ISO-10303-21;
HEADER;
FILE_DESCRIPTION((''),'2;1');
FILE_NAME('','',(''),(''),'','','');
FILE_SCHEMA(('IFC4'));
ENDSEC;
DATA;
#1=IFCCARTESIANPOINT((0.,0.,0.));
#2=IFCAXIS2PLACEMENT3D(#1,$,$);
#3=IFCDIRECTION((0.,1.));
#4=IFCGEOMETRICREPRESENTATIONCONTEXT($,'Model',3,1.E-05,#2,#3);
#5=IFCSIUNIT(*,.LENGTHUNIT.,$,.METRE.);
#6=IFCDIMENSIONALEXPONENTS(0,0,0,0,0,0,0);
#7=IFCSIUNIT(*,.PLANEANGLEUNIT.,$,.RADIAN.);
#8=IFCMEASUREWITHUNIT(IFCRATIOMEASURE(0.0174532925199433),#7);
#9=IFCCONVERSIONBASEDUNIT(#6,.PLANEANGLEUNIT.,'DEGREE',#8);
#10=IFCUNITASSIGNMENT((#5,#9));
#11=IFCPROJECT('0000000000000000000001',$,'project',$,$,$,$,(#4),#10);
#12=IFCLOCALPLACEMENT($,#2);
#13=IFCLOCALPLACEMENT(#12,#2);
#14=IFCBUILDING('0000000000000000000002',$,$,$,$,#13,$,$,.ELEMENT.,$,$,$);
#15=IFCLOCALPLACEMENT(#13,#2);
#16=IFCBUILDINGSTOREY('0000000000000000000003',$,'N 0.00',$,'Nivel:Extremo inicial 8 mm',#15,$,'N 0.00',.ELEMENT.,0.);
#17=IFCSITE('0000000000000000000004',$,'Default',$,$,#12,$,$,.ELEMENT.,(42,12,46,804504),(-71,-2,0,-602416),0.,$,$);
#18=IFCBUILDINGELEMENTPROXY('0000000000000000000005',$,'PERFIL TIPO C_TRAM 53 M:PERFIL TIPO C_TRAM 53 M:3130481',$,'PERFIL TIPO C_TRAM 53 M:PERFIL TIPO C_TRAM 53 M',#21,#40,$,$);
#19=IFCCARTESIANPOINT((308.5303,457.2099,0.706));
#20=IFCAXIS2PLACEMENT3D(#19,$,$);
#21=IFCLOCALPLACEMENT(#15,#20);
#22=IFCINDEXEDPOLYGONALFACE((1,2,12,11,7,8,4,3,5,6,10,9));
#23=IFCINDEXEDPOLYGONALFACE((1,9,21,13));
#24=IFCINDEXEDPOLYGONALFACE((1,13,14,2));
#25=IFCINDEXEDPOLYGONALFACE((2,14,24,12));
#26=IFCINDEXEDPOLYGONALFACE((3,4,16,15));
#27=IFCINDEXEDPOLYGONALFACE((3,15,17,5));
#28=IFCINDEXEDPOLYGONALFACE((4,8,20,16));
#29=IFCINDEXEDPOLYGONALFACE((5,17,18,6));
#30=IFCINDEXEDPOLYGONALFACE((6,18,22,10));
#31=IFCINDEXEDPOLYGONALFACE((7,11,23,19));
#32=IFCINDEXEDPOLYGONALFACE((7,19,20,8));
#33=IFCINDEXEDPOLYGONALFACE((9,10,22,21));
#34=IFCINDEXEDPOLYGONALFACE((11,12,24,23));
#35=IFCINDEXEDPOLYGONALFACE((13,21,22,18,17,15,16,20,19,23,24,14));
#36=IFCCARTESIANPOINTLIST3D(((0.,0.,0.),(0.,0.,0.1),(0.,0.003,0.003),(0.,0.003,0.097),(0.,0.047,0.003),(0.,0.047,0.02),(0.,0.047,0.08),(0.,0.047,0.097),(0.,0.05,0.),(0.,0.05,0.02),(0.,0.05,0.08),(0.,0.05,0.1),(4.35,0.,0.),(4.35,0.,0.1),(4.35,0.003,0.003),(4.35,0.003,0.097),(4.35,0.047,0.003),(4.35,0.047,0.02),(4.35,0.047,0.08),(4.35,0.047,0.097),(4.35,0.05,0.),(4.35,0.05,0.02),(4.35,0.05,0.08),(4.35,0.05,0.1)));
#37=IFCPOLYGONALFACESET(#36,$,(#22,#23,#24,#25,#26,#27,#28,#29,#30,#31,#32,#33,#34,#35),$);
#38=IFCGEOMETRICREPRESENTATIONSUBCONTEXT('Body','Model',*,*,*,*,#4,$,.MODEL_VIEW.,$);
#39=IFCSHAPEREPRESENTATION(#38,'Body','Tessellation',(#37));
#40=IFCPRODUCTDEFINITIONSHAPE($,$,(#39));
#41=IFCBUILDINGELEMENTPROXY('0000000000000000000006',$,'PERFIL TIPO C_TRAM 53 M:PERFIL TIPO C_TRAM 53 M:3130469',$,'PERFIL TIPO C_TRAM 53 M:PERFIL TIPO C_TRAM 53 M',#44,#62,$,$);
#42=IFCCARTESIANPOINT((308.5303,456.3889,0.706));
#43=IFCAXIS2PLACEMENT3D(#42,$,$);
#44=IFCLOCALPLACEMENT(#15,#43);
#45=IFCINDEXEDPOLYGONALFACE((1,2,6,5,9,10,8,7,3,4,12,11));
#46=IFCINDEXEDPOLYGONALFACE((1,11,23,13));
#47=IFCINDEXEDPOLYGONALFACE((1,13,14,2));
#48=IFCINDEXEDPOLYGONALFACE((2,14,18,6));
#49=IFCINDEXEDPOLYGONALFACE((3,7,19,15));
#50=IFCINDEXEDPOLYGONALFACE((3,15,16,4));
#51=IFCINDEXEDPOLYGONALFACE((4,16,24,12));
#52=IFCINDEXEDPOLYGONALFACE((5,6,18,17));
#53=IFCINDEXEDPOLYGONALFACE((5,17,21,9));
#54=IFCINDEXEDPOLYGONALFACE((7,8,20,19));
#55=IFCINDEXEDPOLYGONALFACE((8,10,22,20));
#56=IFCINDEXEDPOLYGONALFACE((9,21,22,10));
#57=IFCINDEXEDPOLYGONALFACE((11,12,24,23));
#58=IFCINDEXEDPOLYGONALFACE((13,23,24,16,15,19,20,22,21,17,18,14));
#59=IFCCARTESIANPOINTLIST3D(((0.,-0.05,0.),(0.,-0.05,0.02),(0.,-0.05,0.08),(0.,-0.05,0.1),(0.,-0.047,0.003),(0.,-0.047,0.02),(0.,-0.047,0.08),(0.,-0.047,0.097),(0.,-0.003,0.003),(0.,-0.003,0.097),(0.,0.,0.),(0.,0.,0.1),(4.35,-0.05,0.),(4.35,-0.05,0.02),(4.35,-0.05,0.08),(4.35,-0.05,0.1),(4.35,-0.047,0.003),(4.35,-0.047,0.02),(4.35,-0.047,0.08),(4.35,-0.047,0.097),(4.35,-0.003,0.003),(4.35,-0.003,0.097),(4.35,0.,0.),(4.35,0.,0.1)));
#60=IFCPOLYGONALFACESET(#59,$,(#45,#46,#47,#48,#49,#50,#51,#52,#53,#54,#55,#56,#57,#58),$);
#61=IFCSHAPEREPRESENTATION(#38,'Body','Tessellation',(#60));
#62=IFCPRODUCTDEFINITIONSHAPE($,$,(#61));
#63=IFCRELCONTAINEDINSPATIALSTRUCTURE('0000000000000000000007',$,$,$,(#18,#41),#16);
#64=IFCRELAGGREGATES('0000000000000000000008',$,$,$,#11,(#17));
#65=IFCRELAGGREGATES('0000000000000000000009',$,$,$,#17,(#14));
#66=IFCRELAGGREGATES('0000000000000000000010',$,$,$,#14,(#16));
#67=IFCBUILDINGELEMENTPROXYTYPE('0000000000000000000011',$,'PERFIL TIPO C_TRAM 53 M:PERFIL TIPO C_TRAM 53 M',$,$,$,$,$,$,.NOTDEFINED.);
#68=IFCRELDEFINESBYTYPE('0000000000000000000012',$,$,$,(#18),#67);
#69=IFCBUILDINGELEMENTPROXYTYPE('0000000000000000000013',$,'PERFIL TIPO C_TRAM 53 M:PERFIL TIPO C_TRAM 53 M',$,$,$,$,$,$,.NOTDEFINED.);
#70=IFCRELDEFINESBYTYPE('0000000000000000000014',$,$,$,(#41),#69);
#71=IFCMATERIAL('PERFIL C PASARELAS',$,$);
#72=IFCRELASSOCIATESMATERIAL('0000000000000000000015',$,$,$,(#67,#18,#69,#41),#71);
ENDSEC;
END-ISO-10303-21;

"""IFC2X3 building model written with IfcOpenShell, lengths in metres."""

from ifc_helpers import new_model, entity, si_unit, converted_unit, direction, frame, origin, place, context, subcontext, project, spatial, polyline, outline, extrude, source, transform, mapped, material, type_object, type_shapes, element, save


model = new_model("IFC2X3")

# Units and contexts
model_context = context("Model", 3, precision=1e-05, world=origin(), true_north=direction((0.0, 1.0)))
body_context = subcontext(model_context, "Body", "Model", "MODEL_VIEW")
ifc_project = project(units=[si_unit("LENGTHUNIT", "METRE"), converted_unit("PLANEANGLEUNIT", "DEGREE", entity("IfcRatioMeasure", 0.0174532925199433), si_unit("PLANEANGLEUNIT", "RADIAN"), dimensions=[0, 0, 0, 0, 0, 0, 0])], contexts=[model_context])

# Site, building, storey
site_placement = place(None, origin())
site = spatial("IfcSite", under=ifc_project, at=site_placement, Name="Default", CompositionType="ELEMENT", RefLatitude=(42, 12, 46, 804504), RefLongitude=(-71, -2, 0, -602416), RefElevation=0.0)
building_placement = place(site_placement, origin())
building = spatial("IfcBuilding", under=site, at=building_placement, CompositionType="ELEMENT")
storey_placement = place(building_placement, origin())
storey = spatial("IfcBuildingStorey", under=building, at=storey_placement, Name="N 0.00", ObjectType="Nivel:Extremo inicial 8 mm", LongName="N 0.00", CompositionType="ELEMENT", Elevation=0.0)

# Building element proxies
ifc_material_1 = material(Name="PERFIL C PASARELAS")
building_element_proxy_type_1 = type_object("IfcBuildingElementProxyType", Name="PERFIL TIPO C_TRAM 53 M:PERFIL TIPO C_TRAM 53 M", PredefinedType="NOTDEFINED", material=ifc_material_1)
shared_shape_1 = source(origin(), body_context, "Body", "SweptSolid", [
    extrude(outline(polyline([(-0.0172, 0.03), (-0.0142, 0.03), (-0.0142, 0.047), (0.0298, 0.047), (0.0298, -0.047), (-0.0142, -0.047), (-0.0142, -0.03), (-0.0172, -0.03), (-0.0172, -0.05), (0.0328, -0.05), (0.0328, 0.05), (-0.0172, 0.05), (-0.0172, 0.03)])), frame((0.0, 0.0328, 0.05), z_axis=(1.0, 0.0, 0.0), x_axis=(0.0, -1.0, 0.0)), (0.0, 0.0, 1.0), 4.35),
])
type_shapes(building_element_proxy_type_1, [shared_shape_1])
proxy_1_placement = place(storey_placement, frame((308.5303, 457.2099, 0.706)))
element("IfcBuildingElementProxy", 1, at=proxy_1_placement, inside=storey, type_object=building_element_proxy_type_1, material=ifc_material_1, Name="PERFIL TIPO C_TRAM 53 M:PERFIL TIPO C_TRAM 53 M:3130481", ObjectType="PERFIL TIPO C_TRAM 53 M:PERFIL TIPO C_TRAM 53 M", context=body_context, shape_type="MappedRepresentation", body=[
    mapped(shared_shape_1, transform((0.0, 0.0, 0.0), scale=1.0)),
])
building_element_proxy_type_2 = type_object("IfcBuildingElementProxyType", Name="PERFIL TIPO C_TRAM 53 M:PERFIL TIPO C_TRAM 53 M", PredefinedType="NOTDEFINED", material=ifc_material_1)
shared_shape_2 = source(origin(), body_context, "Body", "SweptSolid", [
    extrude(outline(polyline([(0.03, -0.0172), (0.05, -0.0172), (0.05, 0.0328), (-0.05, 0.0328), (-0.05, -0.0172), (-0.03, -0.0172), (-0.03, -0.0142), (-0.047, -0.0142), (-0.047, 0.0298), (0.047, 0.0298), (0.047, -0.0142), (0.03, -0.0142), (0.03, -0.0172)])), frame((0.0, -0.0328, 0.05), z_axis=(1.0, 0.0, 0.0), x_axis=(0.0, 0.0, -1.0)), (0.0, 0.0, 1.0), 4.35),
])
type_shapes(building_element_proxy_type_2, [shared_shape_2])
proxy_2_placement = place(storey_placement, frame((308.5303, 456.3889, 0.706)))
element("IfcBuildingElementProxy", 2, at=proxy_2_placement, inside=storey, type_object=building_element_proxy_type_2, material=ifc_material_1, Name="PERFIL TIPO C_TRAM 53 M:PERFIL TIPO C_TRAM 53 M:3130469", ObjectType="PERFIL TIPO C_TRAM 53 M:PERFIL TIPO C_TRAM 53 M", context=body_context, shape_type="MappedRepresentation", body=[
    mapped(shared_shape_2, transform((0.0, 0.0, 0.0), scale=1.0)),
])

save(model, "model.ifc")
